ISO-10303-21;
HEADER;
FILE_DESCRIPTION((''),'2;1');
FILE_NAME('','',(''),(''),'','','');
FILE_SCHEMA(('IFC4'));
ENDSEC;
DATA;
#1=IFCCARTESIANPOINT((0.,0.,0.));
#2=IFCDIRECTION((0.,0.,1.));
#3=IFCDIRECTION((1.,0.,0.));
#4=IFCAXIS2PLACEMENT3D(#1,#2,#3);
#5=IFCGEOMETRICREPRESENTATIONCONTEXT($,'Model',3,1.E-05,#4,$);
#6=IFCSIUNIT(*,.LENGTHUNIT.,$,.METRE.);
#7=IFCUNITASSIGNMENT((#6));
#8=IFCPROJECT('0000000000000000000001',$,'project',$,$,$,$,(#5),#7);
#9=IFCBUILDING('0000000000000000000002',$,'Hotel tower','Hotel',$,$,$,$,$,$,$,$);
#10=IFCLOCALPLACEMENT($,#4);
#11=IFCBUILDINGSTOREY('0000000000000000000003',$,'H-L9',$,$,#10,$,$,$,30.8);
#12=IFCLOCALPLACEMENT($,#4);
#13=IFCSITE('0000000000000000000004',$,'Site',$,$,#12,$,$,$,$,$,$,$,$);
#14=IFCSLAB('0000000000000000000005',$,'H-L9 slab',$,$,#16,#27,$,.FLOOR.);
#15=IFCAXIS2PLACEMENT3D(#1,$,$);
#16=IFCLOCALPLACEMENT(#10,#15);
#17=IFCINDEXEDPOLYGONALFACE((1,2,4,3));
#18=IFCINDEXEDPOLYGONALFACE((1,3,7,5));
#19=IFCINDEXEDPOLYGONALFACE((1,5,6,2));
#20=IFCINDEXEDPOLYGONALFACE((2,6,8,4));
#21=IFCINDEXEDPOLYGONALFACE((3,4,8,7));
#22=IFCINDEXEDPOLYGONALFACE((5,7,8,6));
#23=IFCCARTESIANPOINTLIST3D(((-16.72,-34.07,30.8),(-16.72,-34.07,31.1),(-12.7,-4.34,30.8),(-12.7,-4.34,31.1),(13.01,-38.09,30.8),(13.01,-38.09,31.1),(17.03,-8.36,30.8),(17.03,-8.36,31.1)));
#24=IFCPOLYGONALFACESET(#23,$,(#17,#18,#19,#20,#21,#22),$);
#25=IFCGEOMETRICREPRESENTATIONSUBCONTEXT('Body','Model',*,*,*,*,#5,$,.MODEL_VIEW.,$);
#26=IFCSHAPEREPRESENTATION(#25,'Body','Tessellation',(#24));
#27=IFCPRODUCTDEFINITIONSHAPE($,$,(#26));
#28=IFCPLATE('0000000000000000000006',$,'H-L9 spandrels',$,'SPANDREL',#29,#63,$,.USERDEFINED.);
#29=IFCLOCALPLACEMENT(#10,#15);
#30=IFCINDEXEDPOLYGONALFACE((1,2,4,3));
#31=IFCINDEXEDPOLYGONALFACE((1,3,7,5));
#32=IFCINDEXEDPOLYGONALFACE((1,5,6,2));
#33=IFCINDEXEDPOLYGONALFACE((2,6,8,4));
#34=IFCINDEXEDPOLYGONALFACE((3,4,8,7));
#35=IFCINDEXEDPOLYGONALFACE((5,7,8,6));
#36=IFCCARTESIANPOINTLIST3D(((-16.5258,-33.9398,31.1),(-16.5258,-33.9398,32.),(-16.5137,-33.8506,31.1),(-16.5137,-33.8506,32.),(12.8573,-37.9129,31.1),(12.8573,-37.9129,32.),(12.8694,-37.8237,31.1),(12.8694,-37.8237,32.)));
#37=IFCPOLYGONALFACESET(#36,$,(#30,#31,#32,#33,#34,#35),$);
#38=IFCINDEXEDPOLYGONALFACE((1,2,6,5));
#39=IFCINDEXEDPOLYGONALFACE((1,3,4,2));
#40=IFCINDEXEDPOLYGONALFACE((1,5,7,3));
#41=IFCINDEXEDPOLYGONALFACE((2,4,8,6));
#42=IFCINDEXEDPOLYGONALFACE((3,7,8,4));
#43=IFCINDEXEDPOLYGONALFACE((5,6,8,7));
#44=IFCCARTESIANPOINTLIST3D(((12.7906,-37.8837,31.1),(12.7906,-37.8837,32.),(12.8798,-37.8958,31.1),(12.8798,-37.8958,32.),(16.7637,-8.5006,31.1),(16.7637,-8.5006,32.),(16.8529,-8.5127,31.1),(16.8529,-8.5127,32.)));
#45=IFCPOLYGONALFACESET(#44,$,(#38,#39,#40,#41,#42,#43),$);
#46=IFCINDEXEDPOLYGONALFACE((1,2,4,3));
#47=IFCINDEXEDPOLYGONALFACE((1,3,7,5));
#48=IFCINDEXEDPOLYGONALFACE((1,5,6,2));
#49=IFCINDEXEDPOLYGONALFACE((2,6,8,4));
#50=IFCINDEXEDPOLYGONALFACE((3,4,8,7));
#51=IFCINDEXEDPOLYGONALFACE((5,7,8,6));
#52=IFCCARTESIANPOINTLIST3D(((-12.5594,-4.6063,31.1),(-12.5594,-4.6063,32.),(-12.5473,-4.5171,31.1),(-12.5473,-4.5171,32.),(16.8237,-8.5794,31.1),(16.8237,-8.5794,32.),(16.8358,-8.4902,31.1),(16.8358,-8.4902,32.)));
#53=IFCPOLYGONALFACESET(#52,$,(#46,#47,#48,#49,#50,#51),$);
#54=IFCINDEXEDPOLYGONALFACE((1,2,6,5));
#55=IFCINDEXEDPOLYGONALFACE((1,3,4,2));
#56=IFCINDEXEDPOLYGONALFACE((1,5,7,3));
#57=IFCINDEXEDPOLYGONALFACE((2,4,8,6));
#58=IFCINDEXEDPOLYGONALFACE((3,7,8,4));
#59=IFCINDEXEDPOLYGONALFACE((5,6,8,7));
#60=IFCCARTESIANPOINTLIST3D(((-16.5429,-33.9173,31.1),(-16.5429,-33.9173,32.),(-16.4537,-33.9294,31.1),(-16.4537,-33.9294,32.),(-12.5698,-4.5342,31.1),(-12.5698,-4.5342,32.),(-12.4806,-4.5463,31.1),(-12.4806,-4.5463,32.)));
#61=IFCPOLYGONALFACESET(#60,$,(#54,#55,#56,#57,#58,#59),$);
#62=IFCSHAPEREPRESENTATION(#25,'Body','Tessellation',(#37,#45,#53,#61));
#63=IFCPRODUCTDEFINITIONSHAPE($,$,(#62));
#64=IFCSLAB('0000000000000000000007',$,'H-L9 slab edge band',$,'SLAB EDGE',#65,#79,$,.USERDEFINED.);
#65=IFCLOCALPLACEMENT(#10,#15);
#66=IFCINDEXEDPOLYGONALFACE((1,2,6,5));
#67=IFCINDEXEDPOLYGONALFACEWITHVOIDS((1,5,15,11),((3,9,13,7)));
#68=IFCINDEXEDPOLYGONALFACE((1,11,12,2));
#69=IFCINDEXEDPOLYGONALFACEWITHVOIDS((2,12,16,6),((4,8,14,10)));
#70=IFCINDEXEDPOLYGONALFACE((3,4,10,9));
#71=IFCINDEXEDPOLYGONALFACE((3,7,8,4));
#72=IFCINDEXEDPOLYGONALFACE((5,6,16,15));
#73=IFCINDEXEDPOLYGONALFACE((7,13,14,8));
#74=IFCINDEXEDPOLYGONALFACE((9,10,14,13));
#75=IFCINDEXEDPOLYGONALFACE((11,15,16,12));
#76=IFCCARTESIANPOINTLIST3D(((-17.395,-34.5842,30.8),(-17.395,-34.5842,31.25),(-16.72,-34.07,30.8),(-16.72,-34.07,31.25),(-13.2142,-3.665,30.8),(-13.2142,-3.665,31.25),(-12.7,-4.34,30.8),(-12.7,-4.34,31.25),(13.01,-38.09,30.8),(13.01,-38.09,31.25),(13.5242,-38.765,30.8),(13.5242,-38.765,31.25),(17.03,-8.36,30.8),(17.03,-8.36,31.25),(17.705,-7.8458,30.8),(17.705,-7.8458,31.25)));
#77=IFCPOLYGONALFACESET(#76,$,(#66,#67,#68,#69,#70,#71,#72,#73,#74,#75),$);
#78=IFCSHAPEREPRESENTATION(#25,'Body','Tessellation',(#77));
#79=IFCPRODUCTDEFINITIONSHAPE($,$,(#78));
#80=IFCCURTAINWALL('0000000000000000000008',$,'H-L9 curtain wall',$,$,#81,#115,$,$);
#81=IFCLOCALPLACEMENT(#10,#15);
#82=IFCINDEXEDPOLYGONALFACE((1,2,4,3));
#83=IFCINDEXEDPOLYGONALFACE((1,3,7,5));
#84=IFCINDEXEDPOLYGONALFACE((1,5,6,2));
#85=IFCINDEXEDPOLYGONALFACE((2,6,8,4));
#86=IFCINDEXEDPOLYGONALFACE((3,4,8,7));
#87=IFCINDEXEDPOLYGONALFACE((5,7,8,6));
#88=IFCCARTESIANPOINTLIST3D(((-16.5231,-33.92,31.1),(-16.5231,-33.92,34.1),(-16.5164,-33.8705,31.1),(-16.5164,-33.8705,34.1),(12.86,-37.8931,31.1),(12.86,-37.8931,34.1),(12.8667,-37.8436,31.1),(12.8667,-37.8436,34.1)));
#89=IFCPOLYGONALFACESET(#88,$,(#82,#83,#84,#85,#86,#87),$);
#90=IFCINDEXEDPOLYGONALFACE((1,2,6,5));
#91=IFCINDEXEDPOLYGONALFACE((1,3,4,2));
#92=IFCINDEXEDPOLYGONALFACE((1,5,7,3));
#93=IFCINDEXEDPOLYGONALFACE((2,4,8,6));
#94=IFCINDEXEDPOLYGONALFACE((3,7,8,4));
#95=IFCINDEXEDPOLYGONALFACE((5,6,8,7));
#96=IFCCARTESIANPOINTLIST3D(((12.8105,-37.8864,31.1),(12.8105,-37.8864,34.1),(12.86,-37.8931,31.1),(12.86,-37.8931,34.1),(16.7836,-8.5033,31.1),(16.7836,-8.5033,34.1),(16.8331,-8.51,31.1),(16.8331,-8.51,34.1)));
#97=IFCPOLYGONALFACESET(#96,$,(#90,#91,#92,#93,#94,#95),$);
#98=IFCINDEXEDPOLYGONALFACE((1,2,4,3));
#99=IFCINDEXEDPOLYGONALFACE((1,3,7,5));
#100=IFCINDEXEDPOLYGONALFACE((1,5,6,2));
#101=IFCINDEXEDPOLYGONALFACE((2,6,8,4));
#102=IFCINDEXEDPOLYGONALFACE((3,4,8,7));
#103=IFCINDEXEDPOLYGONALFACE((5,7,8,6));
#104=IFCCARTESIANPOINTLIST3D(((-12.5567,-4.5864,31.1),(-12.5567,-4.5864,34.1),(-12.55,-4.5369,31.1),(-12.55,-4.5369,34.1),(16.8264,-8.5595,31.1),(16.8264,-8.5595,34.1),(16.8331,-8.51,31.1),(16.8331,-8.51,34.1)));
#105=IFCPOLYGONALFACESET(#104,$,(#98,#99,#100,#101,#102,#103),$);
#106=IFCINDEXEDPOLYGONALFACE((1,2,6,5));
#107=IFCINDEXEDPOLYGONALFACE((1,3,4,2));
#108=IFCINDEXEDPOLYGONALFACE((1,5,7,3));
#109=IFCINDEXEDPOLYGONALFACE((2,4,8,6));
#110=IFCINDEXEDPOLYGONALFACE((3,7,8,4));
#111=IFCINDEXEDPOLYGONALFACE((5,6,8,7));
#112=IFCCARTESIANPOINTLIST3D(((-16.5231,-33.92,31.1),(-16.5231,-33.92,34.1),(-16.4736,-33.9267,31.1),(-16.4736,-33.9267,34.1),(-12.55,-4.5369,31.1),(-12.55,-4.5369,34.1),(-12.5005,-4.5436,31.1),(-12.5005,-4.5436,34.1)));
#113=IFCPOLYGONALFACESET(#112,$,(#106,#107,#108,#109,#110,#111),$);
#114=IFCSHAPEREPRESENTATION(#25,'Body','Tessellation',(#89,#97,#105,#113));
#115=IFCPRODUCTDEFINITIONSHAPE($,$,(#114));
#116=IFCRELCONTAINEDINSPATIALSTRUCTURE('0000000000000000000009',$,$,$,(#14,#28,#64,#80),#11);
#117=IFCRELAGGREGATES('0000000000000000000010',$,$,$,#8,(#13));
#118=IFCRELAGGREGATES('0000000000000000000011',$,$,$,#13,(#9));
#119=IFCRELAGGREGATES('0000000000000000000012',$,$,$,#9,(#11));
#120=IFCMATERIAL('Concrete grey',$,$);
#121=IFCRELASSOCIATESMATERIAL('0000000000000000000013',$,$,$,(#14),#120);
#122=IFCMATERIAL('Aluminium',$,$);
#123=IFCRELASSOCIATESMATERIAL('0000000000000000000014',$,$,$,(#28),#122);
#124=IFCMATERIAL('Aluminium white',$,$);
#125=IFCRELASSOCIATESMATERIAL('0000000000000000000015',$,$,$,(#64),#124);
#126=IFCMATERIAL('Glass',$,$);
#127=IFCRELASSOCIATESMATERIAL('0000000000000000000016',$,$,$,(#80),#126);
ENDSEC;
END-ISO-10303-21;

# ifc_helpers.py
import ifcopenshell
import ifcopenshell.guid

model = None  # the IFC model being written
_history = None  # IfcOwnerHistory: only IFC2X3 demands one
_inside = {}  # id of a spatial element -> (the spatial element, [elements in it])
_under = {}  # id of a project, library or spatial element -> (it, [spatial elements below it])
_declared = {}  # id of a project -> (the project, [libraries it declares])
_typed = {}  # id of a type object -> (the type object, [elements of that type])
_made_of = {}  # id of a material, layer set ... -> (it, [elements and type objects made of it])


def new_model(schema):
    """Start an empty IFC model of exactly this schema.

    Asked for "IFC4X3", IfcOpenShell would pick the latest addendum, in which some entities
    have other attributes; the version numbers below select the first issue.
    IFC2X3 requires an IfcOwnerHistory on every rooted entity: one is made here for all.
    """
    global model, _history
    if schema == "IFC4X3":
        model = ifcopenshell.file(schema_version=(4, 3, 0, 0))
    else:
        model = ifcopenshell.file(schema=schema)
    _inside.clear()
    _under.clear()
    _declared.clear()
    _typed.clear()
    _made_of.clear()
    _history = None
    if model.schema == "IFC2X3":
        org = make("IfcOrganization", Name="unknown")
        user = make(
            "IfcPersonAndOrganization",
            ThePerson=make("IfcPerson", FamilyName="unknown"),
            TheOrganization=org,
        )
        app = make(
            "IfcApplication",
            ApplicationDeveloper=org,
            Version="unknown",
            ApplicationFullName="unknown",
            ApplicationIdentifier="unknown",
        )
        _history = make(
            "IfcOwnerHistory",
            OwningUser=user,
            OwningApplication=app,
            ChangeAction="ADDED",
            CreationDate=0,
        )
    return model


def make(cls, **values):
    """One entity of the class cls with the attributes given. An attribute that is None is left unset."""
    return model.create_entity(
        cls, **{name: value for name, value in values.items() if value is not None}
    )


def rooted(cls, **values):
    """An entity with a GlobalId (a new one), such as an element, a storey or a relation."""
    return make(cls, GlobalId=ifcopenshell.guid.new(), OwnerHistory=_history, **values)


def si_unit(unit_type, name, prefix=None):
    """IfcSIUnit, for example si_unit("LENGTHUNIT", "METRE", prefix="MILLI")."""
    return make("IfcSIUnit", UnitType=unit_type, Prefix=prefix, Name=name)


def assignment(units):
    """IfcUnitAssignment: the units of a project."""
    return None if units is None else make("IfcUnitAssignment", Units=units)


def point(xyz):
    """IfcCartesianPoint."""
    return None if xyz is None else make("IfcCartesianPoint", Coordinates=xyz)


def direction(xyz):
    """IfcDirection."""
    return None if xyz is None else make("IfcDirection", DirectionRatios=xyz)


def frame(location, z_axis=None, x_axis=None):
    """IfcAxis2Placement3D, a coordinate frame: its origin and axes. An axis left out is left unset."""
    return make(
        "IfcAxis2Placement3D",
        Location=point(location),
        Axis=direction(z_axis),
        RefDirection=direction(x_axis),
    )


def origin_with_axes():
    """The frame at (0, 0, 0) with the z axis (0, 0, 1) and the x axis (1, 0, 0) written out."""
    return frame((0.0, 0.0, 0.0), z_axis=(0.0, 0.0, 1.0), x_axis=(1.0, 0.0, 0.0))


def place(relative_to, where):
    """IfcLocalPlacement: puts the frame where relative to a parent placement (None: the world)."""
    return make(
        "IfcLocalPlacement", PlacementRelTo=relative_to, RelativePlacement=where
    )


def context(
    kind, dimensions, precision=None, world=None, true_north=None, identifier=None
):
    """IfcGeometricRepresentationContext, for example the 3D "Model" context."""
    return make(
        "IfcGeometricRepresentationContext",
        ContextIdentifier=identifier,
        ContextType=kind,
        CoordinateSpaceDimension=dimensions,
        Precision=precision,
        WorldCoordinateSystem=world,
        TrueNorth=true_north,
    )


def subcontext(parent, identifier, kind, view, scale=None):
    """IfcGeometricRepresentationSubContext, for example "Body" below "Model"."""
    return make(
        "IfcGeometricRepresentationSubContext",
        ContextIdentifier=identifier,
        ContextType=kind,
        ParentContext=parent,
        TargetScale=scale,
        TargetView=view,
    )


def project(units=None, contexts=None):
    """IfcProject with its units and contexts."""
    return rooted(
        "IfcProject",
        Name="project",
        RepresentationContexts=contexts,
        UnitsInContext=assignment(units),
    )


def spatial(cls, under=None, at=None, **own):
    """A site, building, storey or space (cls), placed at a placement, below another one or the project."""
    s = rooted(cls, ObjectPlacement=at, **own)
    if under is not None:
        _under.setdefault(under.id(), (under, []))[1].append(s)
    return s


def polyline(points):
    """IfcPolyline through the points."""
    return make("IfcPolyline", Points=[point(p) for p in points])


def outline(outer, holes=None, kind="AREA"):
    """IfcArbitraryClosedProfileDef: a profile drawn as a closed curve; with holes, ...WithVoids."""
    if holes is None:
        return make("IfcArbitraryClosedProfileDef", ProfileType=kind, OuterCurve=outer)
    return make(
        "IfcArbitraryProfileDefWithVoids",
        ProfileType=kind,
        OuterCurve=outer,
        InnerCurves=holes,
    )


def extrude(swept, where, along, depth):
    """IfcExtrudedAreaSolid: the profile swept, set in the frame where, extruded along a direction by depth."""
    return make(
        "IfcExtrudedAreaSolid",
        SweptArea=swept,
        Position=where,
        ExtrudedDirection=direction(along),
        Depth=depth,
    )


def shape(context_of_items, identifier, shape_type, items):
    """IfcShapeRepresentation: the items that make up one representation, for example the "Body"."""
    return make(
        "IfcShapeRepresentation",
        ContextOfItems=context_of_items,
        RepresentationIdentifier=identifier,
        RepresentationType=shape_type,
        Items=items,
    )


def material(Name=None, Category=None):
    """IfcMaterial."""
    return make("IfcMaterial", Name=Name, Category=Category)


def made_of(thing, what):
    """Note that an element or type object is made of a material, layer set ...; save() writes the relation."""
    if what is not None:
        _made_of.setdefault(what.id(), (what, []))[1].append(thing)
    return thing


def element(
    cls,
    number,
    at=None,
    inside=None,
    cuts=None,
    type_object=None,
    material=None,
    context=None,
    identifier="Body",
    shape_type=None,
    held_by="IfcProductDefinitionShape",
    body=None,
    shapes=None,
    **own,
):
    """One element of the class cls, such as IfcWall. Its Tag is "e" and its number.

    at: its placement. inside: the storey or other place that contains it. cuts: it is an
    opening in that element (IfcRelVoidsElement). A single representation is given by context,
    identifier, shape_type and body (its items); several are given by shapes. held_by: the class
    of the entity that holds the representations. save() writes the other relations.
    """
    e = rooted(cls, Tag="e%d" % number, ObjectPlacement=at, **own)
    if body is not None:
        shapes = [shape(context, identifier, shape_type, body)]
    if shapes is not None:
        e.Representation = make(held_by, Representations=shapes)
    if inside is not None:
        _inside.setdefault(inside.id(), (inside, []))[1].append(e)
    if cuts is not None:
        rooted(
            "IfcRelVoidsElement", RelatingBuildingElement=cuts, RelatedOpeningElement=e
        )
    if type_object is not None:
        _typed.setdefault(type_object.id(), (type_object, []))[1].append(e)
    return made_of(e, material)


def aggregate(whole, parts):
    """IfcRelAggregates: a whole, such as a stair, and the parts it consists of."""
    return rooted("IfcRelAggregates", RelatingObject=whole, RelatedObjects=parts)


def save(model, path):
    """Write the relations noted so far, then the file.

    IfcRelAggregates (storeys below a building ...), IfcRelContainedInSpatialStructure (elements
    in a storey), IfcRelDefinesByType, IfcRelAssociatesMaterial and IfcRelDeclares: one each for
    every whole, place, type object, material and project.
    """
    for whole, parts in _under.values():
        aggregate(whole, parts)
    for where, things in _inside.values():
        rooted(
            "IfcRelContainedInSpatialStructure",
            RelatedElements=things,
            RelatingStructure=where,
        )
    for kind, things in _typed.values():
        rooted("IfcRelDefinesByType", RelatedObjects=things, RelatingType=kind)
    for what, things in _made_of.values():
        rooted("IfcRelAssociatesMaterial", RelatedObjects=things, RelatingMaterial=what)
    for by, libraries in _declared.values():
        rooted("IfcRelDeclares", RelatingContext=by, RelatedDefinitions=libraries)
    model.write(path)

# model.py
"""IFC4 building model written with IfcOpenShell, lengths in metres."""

from ifc_helpers import new_model, si_unit, frame, origin_with_axes, place, context, subcontext, project, spatial, polyline, outline, extrude, material, element, save


model = new_model("IFC4")

# Units and contexts
model_context = context("Model", 3, precision=1e-05, world=origin_with_axes())
body_context = subcontext(model_context, "Body", "Model", "MODEL_VIEW")
ifc_project = project(units=[si_unit("LENGTHUNIT", "METRE")], contexts=[model_context])

# Site, building, storey
site_placement = place(None, origin_with_axes())
site = spatial("IfcSite", under=ifc_project, at=site_placement, Name="Site")
building = spatial("IfcBuilding", under=site, Name="Hotel tower", Description="Hotel")
storey_placement = place(None, origin_with_axes())
storey = spatial("IfcBuildingStorey", under=building, at=storey_placement, Name="H-L9", Elevation=30.8)

# Shared definitions
ifc_material_1 = material(Name="Aluminium")

# Slab
ifc_material_2 = material(Name="Concrete grey")
slab_1_placement = place(storey_placement, origin_with_axes())
element("IfcSlab", 1, at=slab_1_placement, inside=storey, material=ifc_material_2, Name="H-L9 slab", PredefinedType="FLOOR", context=body_context, shape_type="SweptSolid", body=[
    extrude(outline(polyline([(-16.72, -34.07), (13.01, -38.09), (17.03, -8.36), (-12.7, -4.34), (-16.72, -34.07)])), frame((0.0, 0.0, 30.8), z_axis=(0.0, 0.0, 1.0), x_axis=(1.0, 0.0, 0.0)), (0.0, 0.0, 1.0), 0.3),
])

# Plate
plate_placement = place(storey_placement, origin_with_axes())
element("IfcPlate", 2, at=plate_placement, inside=storey, material=ifc_material_1, Name="H-L9 spandrels", ObjectType="SPANDREL", PredefinedType="USERDEFINED", context=body_context, shape_type="SweptSolid", body=[
    extrude(outline(polyline([(-16.5258, -33.9398), (12.8573, -37.9129), (12.8694, -37.8237), (-16.5137, -33.8506), (-16.5258, -33.9398)])), frame((0.0, 0.0, 31.1), z_axis=(0.0, 0.0, 1.0), x_axis=(1.0, 0.0, 0.0)), (0.0, 0.0, 1.0), 0.9),
    extrude(outline(polyline([(12.8798, -37.8958), (16.8529, -8.5127), (16.7637, -8.5006), (12.7906, -37.8837), (12.8798, -37.8958)])), frame((0.0, 0.0, 31.1), z_axis=(0.0, 0.0, 1.0), x_axis=(1.0, 0.0, 0.0)), (0.0, 0.0, 1.0), 0.9),
    extrude(outline(polyline([(16.8358, -8.4902), (-12.5473, -4.5171), (-12.5594, -4.6063), (16.8237, -8.5794), (16.8358, -8.4902)])), frame((0.0, 0.0, 31.1), z_axis=(0.0, 0.0, 1.0), x_axis=(1.0, 0.0, 0.0)), (0.0, 0.0, 1.0), 0.9),
    extrude(outline(polyline([(-12.5698, -4.5342), (-16.5429, -33.9173), (-16.4537, -33.9294), (-12.4806, -4.5463), (-12.5698, -4.5342)])), frame((0.0, 0.0, 31.1), z_axis=(0.0, 0.0, 1.0), x_axis=(1.0, 0.0, 0.0)), (0.0, 0.0, 1.0), 0.9),
])

# Slab
ifc_material_3 = material(Name="Aluminium white")
slab_2_placement = place(storey_placement, origin_with_axes())
element("IfcSlab", 3, at=slab_2_placement, inside=storey, material=ifc_material_3, Name="H-L9 slab edge band", ObjectType="SLAB EDGE", PredefinedType="USERDEFINED", context=body_context, shape_type="SweptSolid", body=[
    extrude(outline(polyline([(-17.395, -34.5842), (13.5242, -38.765), (17.705, -7.8458), (-13.2142, -3.665), (-17.395, -34.5842)]), holes=[polyline([(-16.72, -34.07), (13.01, -38.09), (17.03, -8.36), (-12.7, -4.34), (-16.72, -34.07)])]), frame((0.0, 0.0, 30.8), z_axis=(0.0, 0.0, 1.0), x_axis=(1.0, 0.0, 0.0)), (0.0, 0.0, 1.0), 0.45),
])

# Curtain wall
ifc_material_4 = material(Name="Glass")
curtain_wall_placement = place(storey_placement, origin_with_axes())
element("IfcCurtainWall", 4, at=curtain_wall_placement, inside=storey, material=ifc_material_4, Name="H-L9 curtain wall", context=body_context, shape_type="SweptSolid", body=[
    extrude(outline(polyline([(-16.5231, -33.92), (12.86, -37.8931), (12.8667, -37.8436), (-16.5164, -33.8705), (-16.5231, -33.92)])), frame((0.0, 0.0, 31.1), z_axis=(0.0, 0.0, 1.0), x_axis=(1.0, 0.0, 0.0)), (0.0, 0.0, 1.0), 3.0),
    extrude(outline(polyline([(12.86, -37.8931), (16.8331, -8.51), (16.7836, -8.5033), (12.8105, -37.8864), (12.86, -37.8931)])), frame((0.0, 0.0, 31.1), z_axis=(0.0, 0.0, 1.0), x_axis=(1.0, 0.0, 0.0)), (0.0, 0.0, 1.0), 3.0),
    extrude(outline(polyline([(16.8331, -8.51), (-12.55, -4.5369), (-12.5567, -4.5864), (16.8264, -8.5595), (16.8331, -8.51)])), frame((0.0, 0.0, 31.1), z_axis=(0.0, 0.0, 1.0), x_axis=(1.0, 0.0, 0.0)), (0.0, 0.0, 1.0), 3.0),
    extrude(outline(polyline([(-12.55, -4.5369), (-16.5231, -33.92), (-16.4736, -33.9267), (-12.5005, -4.5436), (-12.55, -4.5369)])), frame((0.0, 0.0, 31.1), z_axis=(0.0, 0.0, 1.0), x_axis=(1.0, 0.0, 0.0)), (0.0, 0.0, 1.0), 3.0),
])

save(model, "model.ifc")
